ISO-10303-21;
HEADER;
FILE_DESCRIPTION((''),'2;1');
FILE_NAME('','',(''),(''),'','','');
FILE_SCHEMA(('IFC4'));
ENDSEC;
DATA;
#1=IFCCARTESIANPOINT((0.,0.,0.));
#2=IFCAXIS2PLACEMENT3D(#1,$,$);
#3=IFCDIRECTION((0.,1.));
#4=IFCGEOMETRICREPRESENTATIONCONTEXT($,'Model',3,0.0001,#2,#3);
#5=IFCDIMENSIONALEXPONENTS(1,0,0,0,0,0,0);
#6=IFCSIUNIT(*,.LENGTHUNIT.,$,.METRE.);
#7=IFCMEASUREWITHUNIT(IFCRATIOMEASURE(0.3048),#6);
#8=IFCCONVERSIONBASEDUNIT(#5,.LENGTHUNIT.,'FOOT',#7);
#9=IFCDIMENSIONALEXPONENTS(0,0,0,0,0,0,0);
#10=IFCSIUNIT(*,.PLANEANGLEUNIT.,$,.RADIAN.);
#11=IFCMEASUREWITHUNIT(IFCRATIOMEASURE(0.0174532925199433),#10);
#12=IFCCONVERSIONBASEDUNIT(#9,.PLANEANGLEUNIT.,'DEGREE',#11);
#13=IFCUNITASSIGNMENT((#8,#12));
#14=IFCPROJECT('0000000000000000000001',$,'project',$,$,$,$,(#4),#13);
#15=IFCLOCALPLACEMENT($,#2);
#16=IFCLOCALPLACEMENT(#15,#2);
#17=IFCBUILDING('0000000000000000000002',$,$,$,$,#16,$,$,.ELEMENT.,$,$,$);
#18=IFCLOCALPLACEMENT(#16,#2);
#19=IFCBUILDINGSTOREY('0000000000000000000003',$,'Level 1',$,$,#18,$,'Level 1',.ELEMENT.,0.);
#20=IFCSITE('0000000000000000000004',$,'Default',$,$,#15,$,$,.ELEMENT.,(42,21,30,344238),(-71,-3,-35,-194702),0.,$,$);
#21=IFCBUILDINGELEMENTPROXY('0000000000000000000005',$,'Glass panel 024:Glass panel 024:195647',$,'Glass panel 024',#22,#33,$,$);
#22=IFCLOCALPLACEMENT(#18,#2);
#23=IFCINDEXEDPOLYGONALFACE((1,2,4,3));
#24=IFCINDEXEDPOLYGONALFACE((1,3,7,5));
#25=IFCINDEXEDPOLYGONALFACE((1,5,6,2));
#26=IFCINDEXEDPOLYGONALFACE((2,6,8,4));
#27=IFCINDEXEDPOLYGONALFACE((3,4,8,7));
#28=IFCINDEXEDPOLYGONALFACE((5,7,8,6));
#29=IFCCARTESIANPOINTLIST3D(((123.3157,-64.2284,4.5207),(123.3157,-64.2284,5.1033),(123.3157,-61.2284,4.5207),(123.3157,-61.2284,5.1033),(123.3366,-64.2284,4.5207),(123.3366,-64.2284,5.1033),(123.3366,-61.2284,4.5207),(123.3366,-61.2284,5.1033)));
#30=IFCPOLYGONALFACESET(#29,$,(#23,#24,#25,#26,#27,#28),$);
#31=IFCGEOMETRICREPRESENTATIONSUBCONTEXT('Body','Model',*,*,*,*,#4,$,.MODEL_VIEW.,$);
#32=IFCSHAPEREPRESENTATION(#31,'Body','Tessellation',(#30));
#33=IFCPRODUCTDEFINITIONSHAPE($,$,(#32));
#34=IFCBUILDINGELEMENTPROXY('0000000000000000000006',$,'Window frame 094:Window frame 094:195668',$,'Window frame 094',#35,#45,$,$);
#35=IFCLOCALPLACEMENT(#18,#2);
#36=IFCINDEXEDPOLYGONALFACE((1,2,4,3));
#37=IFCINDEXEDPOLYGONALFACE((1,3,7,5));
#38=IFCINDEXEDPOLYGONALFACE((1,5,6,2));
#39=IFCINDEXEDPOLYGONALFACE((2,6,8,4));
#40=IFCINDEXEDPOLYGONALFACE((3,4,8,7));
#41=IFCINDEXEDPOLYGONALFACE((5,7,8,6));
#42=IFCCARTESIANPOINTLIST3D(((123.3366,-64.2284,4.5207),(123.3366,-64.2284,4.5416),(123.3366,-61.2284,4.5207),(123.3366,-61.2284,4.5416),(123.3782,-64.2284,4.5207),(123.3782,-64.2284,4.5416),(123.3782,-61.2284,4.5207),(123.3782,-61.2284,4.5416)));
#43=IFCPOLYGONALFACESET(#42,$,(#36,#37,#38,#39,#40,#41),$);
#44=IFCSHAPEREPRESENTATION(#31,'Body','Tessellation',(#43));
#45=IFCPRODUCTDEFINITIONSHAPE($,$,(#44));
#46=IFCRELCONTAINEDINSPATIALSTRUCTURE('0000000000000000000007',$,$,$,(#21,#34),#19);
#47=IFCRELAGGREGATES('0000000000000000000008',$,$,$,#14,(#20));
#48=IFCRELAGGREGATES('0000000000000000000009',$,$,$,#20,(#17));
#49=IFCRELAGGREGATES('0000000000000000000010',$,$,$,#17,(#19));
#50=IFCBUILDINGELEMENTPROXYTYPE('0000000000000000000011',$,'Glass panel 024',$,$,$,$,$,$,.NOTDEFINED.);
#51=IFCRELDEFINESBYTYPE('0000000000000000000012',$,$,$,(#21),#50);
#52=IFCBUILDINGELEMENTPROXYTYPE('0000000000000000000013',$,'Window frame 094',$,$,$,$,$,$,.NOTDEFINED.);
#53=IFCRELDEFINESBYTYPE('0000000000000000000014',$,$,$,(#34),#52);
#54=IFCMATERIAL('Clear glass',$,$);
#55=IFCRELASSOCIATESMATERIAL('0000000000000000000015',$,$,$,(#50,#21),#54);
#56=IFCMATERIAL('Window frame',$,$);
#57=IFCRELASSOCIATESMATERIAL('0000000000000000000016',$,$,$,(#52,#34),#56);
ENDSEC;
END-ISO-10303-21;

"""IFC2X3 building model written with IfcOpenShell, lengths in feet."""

from ifc_helpers import new_model, entity, si_unit, converted_unit, direction, frame, frame_2d, origin, origin_2d_with_axis, place, context, subcontext, project, spatial, rectangle, extrude, source, transform, mapped, material, type_object, type_shapes, element, save


model = new_model("IFC2X3")

# Units and contexts
model_context = context("Model", 3, precision=0.0001, world=origin(), true_north=direction((0.0, 1.0)))
body_context = subcontext(model_context, "Body", "Model", "MODEL_VIEW")
ifc_project = project(units=[converted_unit("LENGTHUNIT", "FOOT", entity("IfcRatioMeasure", 0.3048), si_unit("LENGTHUNIT", "METRE"), dimensions=[1, 0, 0, 0, 0, 0, 0]), converted_unit("PLANEANGLEUNIT", "DEGREE", entity("IfcRatioMeasure", 0.0174532925199433), si_unit("PLANEANGLEUNIT", "RADIAN"), dimensions=[0, 0, 0, 0, 0, 0, 0])], contexts=[model_context])

# Site, building, storey
site_placement = place(None, origin())
site = spatial("IfcSite", under=ifc_project, at=site_placement, Name="Default", CompositionType="ELEMENT", RefLatitude=(42, 21, 30, 344238), RefLongitude=(-71, -3, -35, -194702), RefElevation=0.0)
building_placement = place(site_placement, origin())
building = spatial("IfcBuilding", under=site, at=building_placement, CompositionType="ELEMENT")
storey_placement = place(building_placement, origin())
storey = spatial("IfcBuildingStorey", under=building, at=storey_placement, Name="Level 1", LongName="Level 1", CompositionType="ELEMENT", Elevation=0.0)

# Building element proxies
ifc_material_1 = material(Name="Window frame")
ifc_material_2 = material(Name="Clear glass")
building_element_proxy_type_1 = type_object("IfcBuildingElementProxyType", Name="Glass panel 024", PredefinedType="NOTDEFINED", material=ifc_material_2)
shared_shape_1 = source(origin(), body_context, "Body", "SweptSolid", [
    extrude(rectangle(XDim=3.0, YDim=0.0208, at=origin_2d_with_axis()), frame((123.3262, -62.7284, 4.5207), z_axis=(0.0, 0.0, 1.0), x_axis=(0.0, 1.0, 0.0)), (0.0, 0.0, 1.0), 0.5825),
])
type_shapes(building_element_proxy_type_1, [shared_shape_1])
proxy_1_placement = place(storey_placement, origin())
element("IfcBuildingElementProxy", 1, at=proxy_1_placement, inside=storey, type_object=building_element_proxy_type_1, material=ifc_material_2, Name="Glass panel 024:Glass panel 024:195647", ObjectType="Glass panel 024", context=body_context, shape_type="MappedRepresentation", body=[
    mapped(shared_shape_1, transform((0.0, 0.0, 0.0), scale=1.0)),
])
building_element_proxy_type_2 = type_object("IfcBuildingElementProxyType", Name="Window frame 094", PredefinedType="NOTDEFINED", material=ifc_material_1)
shared_shape_2 = source(origin(), body_context, "Body", "SweptSolid", [
    extrude(rectangle(XDim=3.0, YDim=0.0417, at=frame_2d((0.0, 0.0), x_axis=(1.0, 0.0))), frame((123.3574, -62.7284, 4.5207), z_axis=(0.0, 0.0, 1.0), x_axis=(0.0, 1.0, 0.0)), (0.0, 0.0, 1.0), 0.0208),
])
type_shapes(building_element_proxy_type_2, [shared_shape_2])
proxy_2_placement = place(storey_placement, origin())
element("IfcBuildingElementProxy", 2, at=proxy_2_placement, inside=storey, type_object=building_element_proxy_type_2, material=ifc_material_1, Name="Window frame 094:Window frame 094:195668", ObjectType="Window frame 094", context=body_context, shape_type="MappedRepresentation", body=[
    mapped(shared_shape_2, transform((0.0, 0.0, 0.0), scale=1.0)),
])

save(model, "model.ifc")
